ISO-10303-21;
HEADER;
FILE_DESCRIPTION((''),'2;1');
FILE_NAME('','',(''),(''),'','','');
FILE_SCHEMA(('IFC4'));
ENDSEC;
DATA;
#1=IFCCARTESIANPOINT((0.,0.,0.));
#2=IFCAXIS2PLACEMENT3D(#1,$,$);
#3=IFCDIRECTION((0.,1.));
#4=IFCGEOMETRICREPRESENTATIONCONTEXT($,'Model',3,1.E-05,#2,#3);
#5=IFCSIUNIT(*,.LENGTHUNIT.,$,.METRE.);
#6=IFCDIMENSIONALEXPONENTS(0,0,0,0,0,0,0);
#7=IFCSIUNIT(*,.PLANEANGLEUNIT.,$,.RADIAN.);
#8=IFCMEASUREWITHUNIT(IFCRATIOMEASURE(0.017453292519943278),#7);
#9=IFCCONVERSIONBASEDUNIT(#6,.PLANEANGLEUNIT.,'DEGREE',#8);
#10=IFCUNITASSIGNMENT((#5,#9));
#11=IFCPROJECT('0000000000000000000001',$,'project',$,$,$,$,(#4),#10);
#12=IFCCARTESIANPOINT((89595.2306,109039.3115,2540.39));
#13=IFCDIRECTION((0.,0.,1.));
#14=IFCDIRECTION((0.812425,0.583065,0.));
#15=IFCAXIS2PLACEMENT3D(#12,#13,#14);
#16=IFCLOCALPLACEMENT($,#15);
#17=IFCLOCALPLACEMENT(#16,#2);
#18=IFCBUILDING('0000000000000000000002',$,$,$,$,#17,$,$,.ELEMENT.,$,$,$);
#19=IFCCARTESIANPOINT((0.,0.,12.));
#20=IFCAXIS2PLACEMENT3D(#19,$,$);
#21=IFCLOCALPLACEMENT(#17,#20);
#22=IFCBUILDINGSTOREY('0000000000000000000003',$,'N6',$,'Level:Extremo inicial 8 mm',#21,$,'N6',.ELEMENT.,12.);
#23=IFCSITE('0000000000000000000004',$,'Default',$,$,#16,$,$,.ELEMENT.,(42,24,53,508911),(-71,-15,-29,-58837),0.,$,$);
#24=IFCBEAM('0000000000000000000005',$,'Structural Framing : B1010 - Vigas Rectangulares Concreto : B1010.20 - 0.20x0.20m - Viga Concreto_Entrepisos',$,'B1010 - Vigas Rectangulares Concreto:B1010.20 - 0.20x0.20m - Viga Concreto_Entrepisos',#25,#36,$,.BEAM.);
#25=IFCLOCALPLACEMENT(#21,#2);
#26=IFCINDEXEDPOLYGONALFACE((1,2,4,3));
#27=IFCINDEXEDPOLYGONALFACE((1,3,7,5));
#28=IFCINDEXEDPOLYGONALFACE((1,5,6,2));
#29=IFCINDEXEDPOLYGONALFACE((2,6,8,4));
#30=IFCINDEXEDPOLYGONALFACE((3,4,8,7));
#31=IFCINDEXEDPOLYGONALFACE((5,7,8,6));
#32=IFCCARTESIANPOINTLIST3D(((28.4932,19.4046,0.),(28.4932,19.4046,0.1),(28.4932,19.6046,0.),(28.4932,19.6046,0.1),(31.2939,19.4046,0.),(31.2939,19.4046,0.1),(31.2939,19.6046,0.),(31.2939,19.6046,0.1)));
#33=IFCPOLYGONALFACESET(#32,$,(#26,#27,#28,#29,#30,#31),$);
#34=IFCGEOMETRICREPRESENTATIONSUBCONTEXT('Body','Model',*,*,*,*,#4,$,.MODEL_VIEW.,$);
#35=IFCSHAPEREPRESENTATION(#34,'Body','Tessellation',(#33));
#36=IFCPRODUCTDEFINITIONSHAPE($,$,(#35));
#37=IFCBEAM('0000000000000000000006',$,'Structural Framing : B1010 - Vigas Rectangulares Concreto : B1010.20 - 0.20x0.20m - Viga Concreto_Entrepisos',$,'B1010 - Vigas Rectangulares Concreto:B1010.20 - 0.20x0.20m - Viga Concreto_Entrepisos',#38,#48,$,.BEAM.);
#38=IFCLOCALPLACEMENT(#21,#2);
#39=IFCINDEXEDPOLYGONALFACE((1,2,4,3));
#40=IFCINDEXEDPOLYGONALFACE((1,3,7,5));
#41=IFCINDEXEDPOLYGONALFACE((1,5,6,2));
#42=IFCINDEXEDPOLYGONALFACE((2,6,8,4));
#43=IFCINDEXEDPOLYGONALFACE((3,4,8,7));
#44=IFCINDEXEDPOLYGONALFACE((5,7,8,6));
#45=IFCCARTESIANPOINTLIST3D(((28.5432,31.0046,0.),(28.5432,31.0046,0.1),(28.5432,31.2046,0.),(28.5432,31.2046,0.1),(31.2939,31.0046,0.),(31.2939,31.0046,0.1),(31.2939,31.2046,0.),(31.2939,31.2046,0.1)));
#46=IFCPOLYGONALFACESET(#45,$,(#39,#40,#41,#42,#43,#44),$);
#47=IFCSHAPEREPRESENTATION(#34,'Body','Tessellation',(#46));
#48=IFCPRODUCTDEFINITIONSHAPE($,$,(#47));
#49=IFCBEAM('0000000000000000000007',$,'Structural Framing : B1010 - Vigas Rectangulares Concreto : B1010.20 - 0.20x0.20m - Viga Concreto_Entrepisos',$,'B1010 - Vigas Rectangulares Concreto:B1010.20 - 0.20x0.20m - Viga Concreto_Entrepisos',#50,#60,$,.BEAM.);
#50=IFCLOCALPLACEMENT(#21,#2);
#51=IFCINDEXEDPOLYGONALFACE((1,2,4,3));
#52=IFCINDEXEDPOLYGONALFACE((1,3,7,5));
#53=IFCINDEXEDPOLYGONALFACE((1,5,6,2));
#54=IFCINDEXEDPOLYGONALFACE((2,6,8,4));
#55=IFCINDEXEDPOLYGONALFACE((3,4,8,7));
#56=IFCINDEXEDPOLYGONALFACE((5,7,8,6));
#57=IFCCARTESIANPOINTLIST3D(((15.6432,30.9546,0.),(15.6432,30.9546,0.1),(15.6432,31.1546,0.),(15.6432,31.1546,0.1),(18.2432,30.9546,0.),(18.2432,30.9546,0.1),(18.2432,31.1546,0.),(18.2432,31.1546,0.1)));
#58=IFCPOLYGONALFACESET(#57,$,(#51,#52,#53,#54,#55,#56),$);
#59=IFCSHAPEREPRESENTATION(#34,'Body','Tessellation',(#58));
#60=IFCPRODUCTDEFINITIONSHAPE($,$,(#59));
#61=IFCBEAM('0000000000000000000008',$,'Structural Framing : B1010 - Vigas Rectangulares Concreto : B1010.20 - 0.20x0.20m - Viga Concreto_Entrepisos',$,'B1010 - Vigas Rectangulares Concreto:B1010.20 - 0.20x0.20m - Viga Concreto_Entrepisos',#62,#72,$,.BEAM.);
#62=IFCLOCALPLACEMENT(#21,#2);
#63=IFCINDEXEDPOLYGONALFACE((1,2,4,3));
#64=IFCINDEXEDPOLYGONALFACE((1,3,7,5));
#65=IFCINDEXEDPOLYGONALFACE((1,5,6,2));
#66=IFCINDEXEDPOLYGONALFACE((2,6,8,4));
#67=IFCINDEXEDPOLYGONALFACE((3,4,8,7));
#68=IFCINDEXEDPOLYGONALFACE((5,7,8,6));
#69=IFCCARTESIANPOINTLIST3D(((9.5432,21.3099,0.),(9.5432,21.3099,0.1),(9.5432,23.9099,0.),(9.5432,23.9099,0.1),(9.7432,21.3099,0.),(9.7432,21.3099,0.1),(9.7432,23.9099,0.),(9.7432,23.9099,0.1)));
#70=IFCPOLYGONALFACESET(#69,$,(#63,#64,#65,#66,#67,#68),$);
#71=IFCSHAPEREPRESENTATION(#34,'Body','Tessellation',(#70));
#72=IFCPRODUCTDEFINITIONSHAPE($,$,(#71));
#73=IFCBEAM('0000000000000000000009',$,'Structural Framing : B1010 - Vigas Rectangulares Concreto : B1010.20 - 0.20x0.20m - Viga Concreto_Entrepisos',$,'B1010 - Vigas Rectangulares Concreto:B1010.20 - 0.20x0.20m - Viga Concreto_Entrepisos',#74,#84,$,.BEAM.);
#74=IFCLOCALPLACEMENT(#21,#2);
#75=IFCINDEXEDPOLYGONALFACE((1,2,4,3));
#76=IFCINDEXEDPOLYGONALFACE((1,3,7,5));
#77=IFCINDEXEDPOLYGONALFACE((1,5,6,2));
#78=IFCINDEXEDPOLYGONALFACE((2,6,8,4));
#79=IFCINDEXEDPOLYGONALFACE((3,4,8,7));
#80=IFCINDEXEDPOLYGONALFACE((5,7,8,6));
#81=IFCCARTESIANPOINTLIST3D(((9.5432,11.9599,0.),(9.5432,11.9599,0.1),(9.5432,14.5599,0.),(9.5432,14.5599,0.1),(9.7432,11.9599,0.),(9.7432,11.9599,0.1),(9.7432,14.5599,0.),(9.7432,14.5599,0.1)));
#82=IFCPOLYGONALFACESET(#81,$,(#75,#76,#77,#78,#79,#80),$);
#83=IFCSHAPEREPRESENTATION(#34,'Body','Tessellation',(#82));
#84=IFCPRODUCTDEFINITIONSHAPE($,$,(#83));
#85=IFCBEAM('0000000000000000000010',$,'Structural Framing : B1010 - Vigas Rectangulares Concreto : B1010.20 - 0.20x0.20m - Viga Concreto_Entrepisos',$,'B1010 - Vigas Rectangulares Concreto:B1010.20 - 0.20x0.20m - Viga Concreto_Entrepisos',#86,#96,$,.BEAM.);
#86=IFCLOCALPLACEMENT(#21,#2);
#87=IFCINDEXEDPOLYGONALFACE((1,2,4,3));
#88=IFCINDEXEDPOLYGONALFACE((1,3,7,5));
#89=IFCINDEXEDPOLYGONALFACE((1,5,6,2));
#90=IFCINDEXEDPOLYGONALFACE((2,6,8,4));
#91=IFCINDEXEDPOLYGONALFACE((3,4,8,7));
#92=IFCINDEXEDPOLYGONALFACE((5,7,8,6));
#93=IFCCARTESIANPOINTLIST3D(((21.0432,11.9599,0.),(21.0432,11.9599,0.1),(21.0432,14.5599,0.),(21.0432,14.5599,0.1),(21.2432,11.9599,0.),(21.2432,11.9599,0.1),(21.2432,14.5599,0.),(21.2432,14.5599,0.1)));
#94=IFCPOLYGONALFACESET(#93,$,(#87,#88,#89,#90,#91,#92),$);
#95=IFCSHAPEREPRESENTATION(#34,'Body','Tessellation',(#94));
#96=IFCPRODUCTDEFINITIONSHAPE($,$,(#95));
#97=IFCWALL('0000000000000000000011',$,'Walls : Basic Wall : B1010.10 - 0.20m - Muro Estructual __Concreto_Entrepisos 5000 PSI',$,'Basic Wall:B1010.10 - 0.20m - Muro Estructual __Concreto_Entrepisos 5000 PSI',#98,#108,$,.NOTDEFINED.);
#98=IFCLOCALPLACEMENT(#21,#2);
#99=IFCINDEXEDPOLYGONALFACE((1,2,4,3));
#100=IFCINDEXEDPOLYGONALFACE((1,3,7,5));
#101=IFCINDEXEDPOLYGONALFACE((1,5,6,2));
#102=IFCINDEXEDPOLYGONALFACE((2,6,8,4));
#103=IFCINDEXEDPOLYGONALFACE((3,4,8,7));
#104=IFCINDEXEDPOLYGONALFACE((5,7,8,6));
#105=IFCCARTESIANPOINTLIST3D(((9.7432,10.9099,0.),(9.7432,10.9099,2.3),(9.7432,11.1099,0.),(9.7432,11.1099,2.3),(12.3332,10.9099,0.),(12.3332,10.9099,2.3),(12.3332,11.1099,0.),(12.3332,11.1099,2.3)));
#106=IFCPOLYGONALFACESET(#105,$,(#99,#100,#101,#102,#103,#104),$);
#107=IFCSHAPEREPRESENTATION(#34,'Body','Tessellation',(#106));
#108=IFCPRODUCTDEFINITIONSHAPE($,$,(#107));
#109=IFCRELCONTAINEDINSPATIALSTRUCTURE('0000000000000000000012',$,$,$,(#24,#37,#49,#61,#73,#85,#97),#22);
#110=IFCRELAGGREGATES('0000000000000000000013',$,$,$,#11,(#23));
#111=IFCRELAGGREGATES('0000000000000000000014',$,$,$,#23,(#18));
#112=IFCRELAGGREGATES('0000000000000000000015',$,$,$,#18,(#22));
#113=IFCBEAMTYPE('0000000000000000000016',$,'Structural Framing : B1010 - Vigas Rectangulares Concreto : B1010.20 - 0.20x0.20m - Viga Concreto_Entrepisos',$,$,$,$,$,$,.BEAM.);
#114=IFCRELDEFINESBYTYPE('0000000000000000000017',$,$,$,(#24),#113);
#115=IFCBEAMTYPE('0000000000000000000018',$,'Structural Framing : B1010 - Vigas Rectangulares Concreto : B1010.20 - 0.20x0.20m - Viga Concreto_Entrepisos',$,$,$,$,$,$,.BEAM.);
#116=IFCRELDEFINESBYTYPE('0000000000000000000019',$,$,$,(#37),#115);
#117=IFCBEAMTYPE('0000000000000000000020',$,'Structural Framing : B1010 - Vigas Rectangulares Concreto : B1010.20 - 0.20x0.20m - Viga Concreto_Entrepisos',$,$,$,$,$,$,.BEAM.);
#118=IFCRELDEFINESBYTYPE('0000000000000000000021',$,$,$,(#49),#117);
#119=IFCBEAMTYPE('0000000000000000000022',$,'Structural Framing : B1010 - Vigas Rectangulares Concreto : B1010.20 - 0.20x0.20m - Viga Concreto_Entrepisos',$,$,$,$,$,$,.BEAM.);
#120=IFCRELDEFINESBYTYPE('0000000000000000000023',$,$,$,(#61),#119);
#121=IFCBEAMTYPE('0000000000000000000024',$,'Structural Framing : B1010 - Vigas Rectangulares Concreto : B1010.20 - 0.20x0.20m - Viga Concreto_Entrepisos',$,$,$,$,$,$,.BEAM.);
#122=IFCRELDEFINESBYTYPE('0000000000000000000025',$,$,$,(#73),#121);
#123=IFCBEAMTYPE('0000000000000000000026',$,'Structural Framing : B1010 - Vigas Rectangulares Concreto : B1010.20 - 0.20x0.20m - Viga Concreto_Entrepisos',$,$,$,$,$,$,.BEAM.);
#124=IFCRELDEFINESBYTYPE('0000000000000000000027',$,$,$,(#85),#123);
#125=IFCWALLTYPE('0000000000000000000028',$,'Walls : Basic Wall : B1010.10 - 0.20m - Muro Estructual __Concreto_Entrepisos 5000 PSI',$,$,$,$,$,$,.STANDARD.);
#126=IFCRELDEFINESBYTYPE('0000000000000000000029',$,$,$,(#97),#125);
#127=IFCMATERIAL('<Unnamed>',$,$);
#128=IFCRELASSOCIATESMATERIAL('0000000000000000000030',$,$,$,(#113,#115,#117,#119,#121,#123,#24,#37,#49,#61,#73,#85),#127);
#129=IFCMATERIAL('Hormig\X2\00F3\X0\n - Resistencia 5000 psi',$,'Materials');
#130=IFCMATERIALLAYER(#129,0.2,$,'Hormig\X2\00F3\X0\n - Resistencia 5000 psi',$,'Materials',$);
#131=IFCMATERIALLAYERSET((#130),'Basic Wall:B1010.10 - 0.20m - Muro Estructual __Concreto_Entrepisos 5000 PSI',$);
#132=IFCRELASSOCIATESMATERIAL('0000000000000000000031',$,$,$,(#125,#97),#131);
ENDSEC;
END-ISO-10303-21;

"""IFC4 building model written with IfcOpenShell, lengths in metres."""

from ifc_helpers import new_model, entity, si_unit, converted_unit, direction, frame, frame_2d, origin, place, context, subcontext, project, spatial, polyline, segment, composite_curve, rectangle, outline, extrude, source, transform, mapped, material, layer, layer_set, layer_usage, material_profile, profile_set, profile_usage, type_object, type_shapes, element, save


model = new_model("IFC4")

# Units and contexts
model_context = context("Model", 3, precision=1e-05, world=origin(), true_north=direction((0.0, 1.0)))
body_context = subcontext(model_context, "Body", "Model", "MODEL_VIEW")
ifc_project = project(units=[si_unit("LENGTHUNIT", "METRE"), converted_unit("PLANEANGLEUNIT", "DEGREE", entity("IfcRatioMeasure", 0.017453292519943278), si_unit("PLANEANGLEUNIT", "RADIAN"), dimensions=[0, 0, 0, 0, 0, 0, 0])], contexts=[model_context])

# Site, building, storey
site_placement = place(None, frame((89595.2306, 109039.3115, 2540.39), z_axis=(0.0, 0.0, 1.0), x_axis=(0.812425, 0.583065, 0.0)))
site = spatial("IfcSite", under=ifc_project, at=site_placement, Name="Default", CompositionType="ELEMENT", RefLatitude=(42, 24, 53, 508911), RefLongitude=(-71, -15, -29, -58837), RefElevation=0.0)
building_placement = place(site_placement, origin())
building = spatial("IfcBuilding", under=site, at=building_placement, CompositionType="ELEMENT")
storey_placement = place(building_placement, frame((0.0, 0.0, 12.0)))
storey = spatial("IfcBuildingStorey", under=building, at=storey_placement, Name="N6", ObjectType="Level:Extremo inicial 8 mm", LongName="N6", CompositionType="ELEMENT", Elevation=12.0)

# Beams
ifc_material_1 = material(Name="<Unnamed>")
ifc_material_profile_1 = material_profile(ifc_material_1, outline(composite_curve([segment(polyline([(-0.1, 0.0, 0.0), (-0.1, 0.1, 0.0)]), True, "CONTINUOUS"), segment(polyline([(-0.1, 0.1, 0.0), (0.1, 0.1, 0.0)]), True, "CONTINUOUS"), segment(polyline([(0.1, 0.1, 0.0), (0.1, 0.0, 0.0)]), True, "CONTINUOUS"), segment(polyline([(0.1, 0.0, 0.0), (-0.1, 0.0, 0.0)]), True, "CONTINUOUS")], self_intersect=False), kind="CURVE"), Name="B1010.20 - 0.20x0.20m - Viga Concreto_Entrepisos")
ifc_material_profile_2 = material_profile(ifc_material_1, outline(composite_curve([segment(polyline([(-1.4004, -0.1, 0.1), (-1.4004, 0.1, 0.1)]), True, "CONTINUOUS"), segment(polyline([(-1.4004, 0.1, 0.1), (-1.4004, 0.1, -0.1)]), True, "CONTINUOUS"), segment(polyline([(-1.4004, 0.1, -0.1), (-1.4004, -0.1, -0.1)]), True, "CONTINUOUS"), segment(polyline([(-1.4004, -0.1, -0.1), (-1.4004, -0.1, 0.1)]), True, "CONTINUOUS")], self_intersect=False), kind="CURVE"), Name="B1010.20 - 0.20x0.20m - Viga Concreto_Entrepisos")
ifc_profile_set_1 = profile_set([ifc_material_profile_1, ifc_material_profile_2], Name="B1010.20 - 0.20x0.20m - Viga Concreto_Entrepisos")
ifc_profile_usage_1 = profile_usage(ifc_profile_set_1, cardinal=8)
beam_type_1 = type_object("IfcBeamType", Name="Structural Framing : B1010 - Vigas Rectangulares Concreto : B1010.20 - 0.20x0.20m - Viga Concreto_Entrepisos", PredefinedType="BEAM", material=ifc_profile_set_1)
shared_shape_1 = source(origin(), body_context, "Body", "SweptSolid", [
    extrude(rectangle(XDim=0.1, YDim=0.2, at=frame_2d((0.0, 0.0), x_axis=(1.0, 0.0))), frame((31.2939, 19.5046, 12.05), z_axis=(-1.0, 0.0, 0.0), x_axis=(0.0, 0.0, -1.0)), (0.0, 0.0, 1.0), 2.8007),
])
type_shapes(beam_type_1, [shared_shape_1])
beam_1_placement = place(storey_placement, frame((0.0, 0.0, -12.0)))
element("IfcBeam", 1, at=beam_1_placement, inside=storey, type_object=beam_type_1, material=ifc_profile_usage_1, Name="Structural Framing : B1010 - Vigas Rectangulares Concreto : B1010.20 - 0.20x0.20m - Viga Concreto_Entrepisos", ObjectType="B1010 - Vigas Rectangulares Concreto:B1010.20 - 0.20x0.20m - Viga Concreto_Entrepisos", PredefinedType="BEAM", context=body_context, shape_type="MappedRepresentation", body=[
    mapped(shared_shape_1, transform((0.0, 0.0, 0.0), scale=1.0)),
])
ifc_profile_usage_2 = profile_usage(ifc_profile_set_1, cardinal=8)
beam_type_2 = type_object("IfcBeamType", Name="Structural Framing : B1010 - Vigas Rectangulares Concreto : B1010.20 - 0.20x0.20m - Viga Concreto_Entrepisos", PredefinedType="BEAM", material=ifc_profile_set_1)
shared_shape_2 = source(origin(), body_context, "Body", "SweptSolid", [
    extrude(rectangle(XDim=0.1, YDim=0.2, at=frame_2d((0.0, 0.0), x_axis=(1.0, 0.0))), frame((31.2939, 31.1046, 12.05), z_axis=(-1.0, 0.0, 0.0), x_axis=(0.0, 0.0, -1.0)), (0.0, 0.0, 1.0), 2.7507),
])
type_shapes(beam_type_2, [shared_shape_2])
beam_2_placement = place(storey_placement, frame((0.0, 0.0, -12.0)))
element("IfcBeam", 2, at=beam_2_placement, inside=storey, type_object=beam_type_2, material=ifc_profile_usage_2, Name="Structural Framing : B1010 - Vigas Rectangulares Concreto : B1010.20 - 0.20x0.20m - Viga Concreto_Entrepisos", ObjectType="B1010 - Vigas Rectangulares Concreto:B1010.20 - 0.20x0.20m - Viga Concreto_Entrepisos", PredefinedType="BEAM", context=body_context, shape_type="MappedRepresentation", body=[
    mapped(shared_shape_2, transform((0.0, 0.0, 0.0), scale=1.0)),
])
ifc_profile_usage_3 = profile_usage(ifc_profile_set_1, cardinal=8)
beam_type_3 = type_object("IfcBeamType", Name="Structural Framing : B1010 - Vigas Rectangulares Concreto : B1010.20 - 0.20x0.20m - Viga Concreto_Entrepisos", PredefinedType="BEAM", material=ifc_profile_set_1)
shared_shape_3 = source(origin(), body_context, "Body", "SweptSolid", [
    extrude(rectangle(XDim=0.1, YDim=0.2, at=frame_2d((0.0, 0.0), x_axis=(1.0, 0.0))), frame((18.2432, 31.0546, 12.05), z_axis=(-1.0, 0.0, 0.0), x_axis=(0.0, 0.0, -1.0)), (0.0, 0.0, 1.0), 2.6),
])
type_shapes(beam_type_3, [shared_shape_3])
beam_3_placement = place(storey_placement, frame((0.0, 0.0, -12.0)))
element("IfcBeam", 3, at=beam_3_placement, inside=storey, type_object=beam_type_3, material=ifc_profile_usage_3, Name="Structural Framing : B1010 - Vigas Rectangulares Concreto : B1010.20 - 0.20x0.20m - Viga Concreto_Entrepisos", ObjectType="B1010 - Vigas Rectangulares Concreto:B1010.20 - 0.20x0.20m - Viga Concreto_Entrepisos", PredefinedType="BEAM", context=body_context, shape_type="MappedRepresentation", body=[
    mapped(shared_shape_3, transform((0.0, 0.0, 0.0), scale=1.0)),
])
ifc_profile_usage_4 = profile_usage(ifc_profile_set_1, cardinal=8)
beam_type_4 = type_object("IfcBeamType", Name="Structural Framing : B1010 - Vigas Rectangulares Concreto : B1010.20 - 0.20x0.20m - Viga Concreto_Entrepisos", PredefinedType="BEAM", material=ifc_profile_set_1)
shared_shape_4 = source(origin(), body_context, "Body", "SweptSolid", [
    extrude(rectangle(XDim=0.1, YDim=0.2, at=frame_2d((0.0, 0.0), x_axis=(0.0, 1.0))), frame((9.6432, 21.3099, 12.05), z_axis=(0.0, 1.0, 0.0), x_axis=(-1.0, 0.0, 0.0)), (0.0, 0.0, 1.0), 2.6),
])
type_shapes(beam_type_4, [shared_shape_4])
beam_4_placement = place(storey_placement, frame((0.0, 0.0, -12.0)))
element("IfcBeam", 4, at=beam_4_placement, inside=storey, type_object=beam_type_4, material=ifc_profile_usage_4, Name="Structural Framing : B1010 - Vigas Rectangulares Concreto : B1010.20 - 0.20x0.20m - Viga Concreto_Entrepisos", ObjectType="B1010 - Vigas Rectangulares Concreto:B1010.20 - 0.20x0.20m - Viga Concreto_Entrepisos", PredefinedType="BEAM", context=body_context, shape_type="MappedRepresentation", body=[
    mapped(shared_shape_4, transform((0.0, 0.0, 0.0), scale=1.0)),
])
ifc_profile_usage_5 = profile_usage(ifc_profile_set_1, cardinal=8)
beam_type_5 = type_object("IfcBeamType", Name="Structural Framing : B1010 - Vigas Rectangulares Concreto : B1010.20 - 0.20x0.20m - Viga Concreto_Entrepisos", PredefinedType="BEAM", material=ifc_profile_set_1)
shared_shape_5 = source(origin(), body_context, "Body", "SweptSolid", [
    extrude(rectangle(XDim=0.1, YDim=0.2, at=frame_2d((0.0, 0.0), x_axis=(0.0, 1.0))), frame((9.6432, 11.9599, 12.05), z_axis=(0.0, 1.0, 0.0), x_axis=(-1.0, 0.0, 0.0)), (0.0, 0.0, 1.0), 2.6),
])
type_shapes(beam_type_5, [shared_shape_5])
beam_5_placement = place(storey_placement, frame((0.0, 0.0, -12.0)))
element("IfcBeam", 5, at=beam_5_placement, inside=storey, type_object=beam_type_5, material=ifc_profile_usage_5, Name="Structural Framing : B1010 - Vigas Rectangulares Concreto : B1010.20 - 0.20x0.20m - Viga Concreto_Entrepisos", ObjectType="B1010 - Vigas Rectangulares Concreto:B1010.20 - 0.20x0.20m - Viga Concreto_Entrepisos", PredefinedType="BEAM", context=body_context, shape_type="MappedRepresentation", body=[
    mapped(shared_shape_5, transform((0.0, 0.0, 0.0), scale=1.0)),
])
ifc_profile_usage_6 = profile_usage(ifc_profile_set_1, cardinal=8)
beam_type_6 = type_object("IfcBeamType", Name="Structural Framing : B1010 - Vigas Rectangulares Concreto : B1010.20 - 0.20x0.20m - Viga Concreto_Entrepisos", PredefinedType="BEAM", material=ifc_profile_set_1)
shared_shape_6 = source(origin(), body_context, "Body", "SweptSolid", [
    extrude(rectangle(XDim=0.1, YDim=0.2, at=frame_2d((0.0, 0.0), x_axis=(0.0, 1.0))), frame((21.1432, 11.9599, 12.05), z_axis=(0.0, 1.0, 0.0), x_axis=(-1.0, 0.0, 0.0)), (0.0, 0.0, 1.0), 2.6),
])
type_shapes(beam_type_6, [shared_shape_6])
beam_6_placement = place(storey_placement, frame((0.0, 0.0, -12.0)))
element("IfcBeam", 6, at=beam_6_placement, inside=storey, type_object=beam_type_6, material=ifc_profile_usage_6, Name="Structural Framing : B1010 - Vigas Rectangulares Concreto : B1010.20 - 0.20x0.20m - Viga Concreto_Entrepisos", ObjectType="B1010 - Vigas Rectangulares Concreto:B1010.20 - 0.20x0.20m - Viga Concreto_Entrepisos", PredefinedType="BEAM", context=body_context, shape_type="MappedRepresentation", body=[
    mapped(shared_shape_6, transform((0.0, 0.0, 0.0), scale=1.0)),
])

# Wall
ifc_material_2 = material(Name="Hormigón - Resistencia 5000 psi", Category="Materials")
ifc_layer_1 = layer(ifc_material_2, 0.2, Name="Hormigón - Resistencia 5000 psi", Category="Materials")
ifc_layer_set_1 = layer_set([ifc_layer_1], Name="Basic Wall:B1010.10 - 0.20m - Muro Estructual __Concreto_Entrepisos 5000 PSI")
ifc_layer_usage_1 = layer_usage(ifc_layer_set_1, "AXIS2", "POSITIVE", -0.1)
wall_type = type_object("IfcWallType", Name="Walls : Basic Wall : B1010.10 - 0.20m - Muro Estructual __Concreto_Entrepisos 5000 PSI", PredefinedType="STANDARD", material=ifc_layer_set_1)
wall_placement = place(storey_placement, frame((9.7432, 11.0099, 0.0)))
element("IfcWall", 7, at=wall_placement, inside=storey, type_object=wall_type, material=ifc_layer_usage_1, Name="Walls : Basic Wall : B1010.10 - 0.20m - Muro Estructual __Concreto_Entrepisos 5000 PSI", ObjectType="Basic Wall:B1010.10 - 0.20m - Muro Estructual __Concreto_Entrepisos 5000 PSI", PredefinedType="NOTDEFINED", context=body_context, shape_type="SweptSolid", body=[
    extrude(rectangle(XDim=2.59, YDim=0.2, at=frame_2d((1.295, 0.0), x_axis=(-1.0, 0.0))), origin(), (0.0, 0.0, 1.0), 2.3),
])

save(model, "model.ifc")
